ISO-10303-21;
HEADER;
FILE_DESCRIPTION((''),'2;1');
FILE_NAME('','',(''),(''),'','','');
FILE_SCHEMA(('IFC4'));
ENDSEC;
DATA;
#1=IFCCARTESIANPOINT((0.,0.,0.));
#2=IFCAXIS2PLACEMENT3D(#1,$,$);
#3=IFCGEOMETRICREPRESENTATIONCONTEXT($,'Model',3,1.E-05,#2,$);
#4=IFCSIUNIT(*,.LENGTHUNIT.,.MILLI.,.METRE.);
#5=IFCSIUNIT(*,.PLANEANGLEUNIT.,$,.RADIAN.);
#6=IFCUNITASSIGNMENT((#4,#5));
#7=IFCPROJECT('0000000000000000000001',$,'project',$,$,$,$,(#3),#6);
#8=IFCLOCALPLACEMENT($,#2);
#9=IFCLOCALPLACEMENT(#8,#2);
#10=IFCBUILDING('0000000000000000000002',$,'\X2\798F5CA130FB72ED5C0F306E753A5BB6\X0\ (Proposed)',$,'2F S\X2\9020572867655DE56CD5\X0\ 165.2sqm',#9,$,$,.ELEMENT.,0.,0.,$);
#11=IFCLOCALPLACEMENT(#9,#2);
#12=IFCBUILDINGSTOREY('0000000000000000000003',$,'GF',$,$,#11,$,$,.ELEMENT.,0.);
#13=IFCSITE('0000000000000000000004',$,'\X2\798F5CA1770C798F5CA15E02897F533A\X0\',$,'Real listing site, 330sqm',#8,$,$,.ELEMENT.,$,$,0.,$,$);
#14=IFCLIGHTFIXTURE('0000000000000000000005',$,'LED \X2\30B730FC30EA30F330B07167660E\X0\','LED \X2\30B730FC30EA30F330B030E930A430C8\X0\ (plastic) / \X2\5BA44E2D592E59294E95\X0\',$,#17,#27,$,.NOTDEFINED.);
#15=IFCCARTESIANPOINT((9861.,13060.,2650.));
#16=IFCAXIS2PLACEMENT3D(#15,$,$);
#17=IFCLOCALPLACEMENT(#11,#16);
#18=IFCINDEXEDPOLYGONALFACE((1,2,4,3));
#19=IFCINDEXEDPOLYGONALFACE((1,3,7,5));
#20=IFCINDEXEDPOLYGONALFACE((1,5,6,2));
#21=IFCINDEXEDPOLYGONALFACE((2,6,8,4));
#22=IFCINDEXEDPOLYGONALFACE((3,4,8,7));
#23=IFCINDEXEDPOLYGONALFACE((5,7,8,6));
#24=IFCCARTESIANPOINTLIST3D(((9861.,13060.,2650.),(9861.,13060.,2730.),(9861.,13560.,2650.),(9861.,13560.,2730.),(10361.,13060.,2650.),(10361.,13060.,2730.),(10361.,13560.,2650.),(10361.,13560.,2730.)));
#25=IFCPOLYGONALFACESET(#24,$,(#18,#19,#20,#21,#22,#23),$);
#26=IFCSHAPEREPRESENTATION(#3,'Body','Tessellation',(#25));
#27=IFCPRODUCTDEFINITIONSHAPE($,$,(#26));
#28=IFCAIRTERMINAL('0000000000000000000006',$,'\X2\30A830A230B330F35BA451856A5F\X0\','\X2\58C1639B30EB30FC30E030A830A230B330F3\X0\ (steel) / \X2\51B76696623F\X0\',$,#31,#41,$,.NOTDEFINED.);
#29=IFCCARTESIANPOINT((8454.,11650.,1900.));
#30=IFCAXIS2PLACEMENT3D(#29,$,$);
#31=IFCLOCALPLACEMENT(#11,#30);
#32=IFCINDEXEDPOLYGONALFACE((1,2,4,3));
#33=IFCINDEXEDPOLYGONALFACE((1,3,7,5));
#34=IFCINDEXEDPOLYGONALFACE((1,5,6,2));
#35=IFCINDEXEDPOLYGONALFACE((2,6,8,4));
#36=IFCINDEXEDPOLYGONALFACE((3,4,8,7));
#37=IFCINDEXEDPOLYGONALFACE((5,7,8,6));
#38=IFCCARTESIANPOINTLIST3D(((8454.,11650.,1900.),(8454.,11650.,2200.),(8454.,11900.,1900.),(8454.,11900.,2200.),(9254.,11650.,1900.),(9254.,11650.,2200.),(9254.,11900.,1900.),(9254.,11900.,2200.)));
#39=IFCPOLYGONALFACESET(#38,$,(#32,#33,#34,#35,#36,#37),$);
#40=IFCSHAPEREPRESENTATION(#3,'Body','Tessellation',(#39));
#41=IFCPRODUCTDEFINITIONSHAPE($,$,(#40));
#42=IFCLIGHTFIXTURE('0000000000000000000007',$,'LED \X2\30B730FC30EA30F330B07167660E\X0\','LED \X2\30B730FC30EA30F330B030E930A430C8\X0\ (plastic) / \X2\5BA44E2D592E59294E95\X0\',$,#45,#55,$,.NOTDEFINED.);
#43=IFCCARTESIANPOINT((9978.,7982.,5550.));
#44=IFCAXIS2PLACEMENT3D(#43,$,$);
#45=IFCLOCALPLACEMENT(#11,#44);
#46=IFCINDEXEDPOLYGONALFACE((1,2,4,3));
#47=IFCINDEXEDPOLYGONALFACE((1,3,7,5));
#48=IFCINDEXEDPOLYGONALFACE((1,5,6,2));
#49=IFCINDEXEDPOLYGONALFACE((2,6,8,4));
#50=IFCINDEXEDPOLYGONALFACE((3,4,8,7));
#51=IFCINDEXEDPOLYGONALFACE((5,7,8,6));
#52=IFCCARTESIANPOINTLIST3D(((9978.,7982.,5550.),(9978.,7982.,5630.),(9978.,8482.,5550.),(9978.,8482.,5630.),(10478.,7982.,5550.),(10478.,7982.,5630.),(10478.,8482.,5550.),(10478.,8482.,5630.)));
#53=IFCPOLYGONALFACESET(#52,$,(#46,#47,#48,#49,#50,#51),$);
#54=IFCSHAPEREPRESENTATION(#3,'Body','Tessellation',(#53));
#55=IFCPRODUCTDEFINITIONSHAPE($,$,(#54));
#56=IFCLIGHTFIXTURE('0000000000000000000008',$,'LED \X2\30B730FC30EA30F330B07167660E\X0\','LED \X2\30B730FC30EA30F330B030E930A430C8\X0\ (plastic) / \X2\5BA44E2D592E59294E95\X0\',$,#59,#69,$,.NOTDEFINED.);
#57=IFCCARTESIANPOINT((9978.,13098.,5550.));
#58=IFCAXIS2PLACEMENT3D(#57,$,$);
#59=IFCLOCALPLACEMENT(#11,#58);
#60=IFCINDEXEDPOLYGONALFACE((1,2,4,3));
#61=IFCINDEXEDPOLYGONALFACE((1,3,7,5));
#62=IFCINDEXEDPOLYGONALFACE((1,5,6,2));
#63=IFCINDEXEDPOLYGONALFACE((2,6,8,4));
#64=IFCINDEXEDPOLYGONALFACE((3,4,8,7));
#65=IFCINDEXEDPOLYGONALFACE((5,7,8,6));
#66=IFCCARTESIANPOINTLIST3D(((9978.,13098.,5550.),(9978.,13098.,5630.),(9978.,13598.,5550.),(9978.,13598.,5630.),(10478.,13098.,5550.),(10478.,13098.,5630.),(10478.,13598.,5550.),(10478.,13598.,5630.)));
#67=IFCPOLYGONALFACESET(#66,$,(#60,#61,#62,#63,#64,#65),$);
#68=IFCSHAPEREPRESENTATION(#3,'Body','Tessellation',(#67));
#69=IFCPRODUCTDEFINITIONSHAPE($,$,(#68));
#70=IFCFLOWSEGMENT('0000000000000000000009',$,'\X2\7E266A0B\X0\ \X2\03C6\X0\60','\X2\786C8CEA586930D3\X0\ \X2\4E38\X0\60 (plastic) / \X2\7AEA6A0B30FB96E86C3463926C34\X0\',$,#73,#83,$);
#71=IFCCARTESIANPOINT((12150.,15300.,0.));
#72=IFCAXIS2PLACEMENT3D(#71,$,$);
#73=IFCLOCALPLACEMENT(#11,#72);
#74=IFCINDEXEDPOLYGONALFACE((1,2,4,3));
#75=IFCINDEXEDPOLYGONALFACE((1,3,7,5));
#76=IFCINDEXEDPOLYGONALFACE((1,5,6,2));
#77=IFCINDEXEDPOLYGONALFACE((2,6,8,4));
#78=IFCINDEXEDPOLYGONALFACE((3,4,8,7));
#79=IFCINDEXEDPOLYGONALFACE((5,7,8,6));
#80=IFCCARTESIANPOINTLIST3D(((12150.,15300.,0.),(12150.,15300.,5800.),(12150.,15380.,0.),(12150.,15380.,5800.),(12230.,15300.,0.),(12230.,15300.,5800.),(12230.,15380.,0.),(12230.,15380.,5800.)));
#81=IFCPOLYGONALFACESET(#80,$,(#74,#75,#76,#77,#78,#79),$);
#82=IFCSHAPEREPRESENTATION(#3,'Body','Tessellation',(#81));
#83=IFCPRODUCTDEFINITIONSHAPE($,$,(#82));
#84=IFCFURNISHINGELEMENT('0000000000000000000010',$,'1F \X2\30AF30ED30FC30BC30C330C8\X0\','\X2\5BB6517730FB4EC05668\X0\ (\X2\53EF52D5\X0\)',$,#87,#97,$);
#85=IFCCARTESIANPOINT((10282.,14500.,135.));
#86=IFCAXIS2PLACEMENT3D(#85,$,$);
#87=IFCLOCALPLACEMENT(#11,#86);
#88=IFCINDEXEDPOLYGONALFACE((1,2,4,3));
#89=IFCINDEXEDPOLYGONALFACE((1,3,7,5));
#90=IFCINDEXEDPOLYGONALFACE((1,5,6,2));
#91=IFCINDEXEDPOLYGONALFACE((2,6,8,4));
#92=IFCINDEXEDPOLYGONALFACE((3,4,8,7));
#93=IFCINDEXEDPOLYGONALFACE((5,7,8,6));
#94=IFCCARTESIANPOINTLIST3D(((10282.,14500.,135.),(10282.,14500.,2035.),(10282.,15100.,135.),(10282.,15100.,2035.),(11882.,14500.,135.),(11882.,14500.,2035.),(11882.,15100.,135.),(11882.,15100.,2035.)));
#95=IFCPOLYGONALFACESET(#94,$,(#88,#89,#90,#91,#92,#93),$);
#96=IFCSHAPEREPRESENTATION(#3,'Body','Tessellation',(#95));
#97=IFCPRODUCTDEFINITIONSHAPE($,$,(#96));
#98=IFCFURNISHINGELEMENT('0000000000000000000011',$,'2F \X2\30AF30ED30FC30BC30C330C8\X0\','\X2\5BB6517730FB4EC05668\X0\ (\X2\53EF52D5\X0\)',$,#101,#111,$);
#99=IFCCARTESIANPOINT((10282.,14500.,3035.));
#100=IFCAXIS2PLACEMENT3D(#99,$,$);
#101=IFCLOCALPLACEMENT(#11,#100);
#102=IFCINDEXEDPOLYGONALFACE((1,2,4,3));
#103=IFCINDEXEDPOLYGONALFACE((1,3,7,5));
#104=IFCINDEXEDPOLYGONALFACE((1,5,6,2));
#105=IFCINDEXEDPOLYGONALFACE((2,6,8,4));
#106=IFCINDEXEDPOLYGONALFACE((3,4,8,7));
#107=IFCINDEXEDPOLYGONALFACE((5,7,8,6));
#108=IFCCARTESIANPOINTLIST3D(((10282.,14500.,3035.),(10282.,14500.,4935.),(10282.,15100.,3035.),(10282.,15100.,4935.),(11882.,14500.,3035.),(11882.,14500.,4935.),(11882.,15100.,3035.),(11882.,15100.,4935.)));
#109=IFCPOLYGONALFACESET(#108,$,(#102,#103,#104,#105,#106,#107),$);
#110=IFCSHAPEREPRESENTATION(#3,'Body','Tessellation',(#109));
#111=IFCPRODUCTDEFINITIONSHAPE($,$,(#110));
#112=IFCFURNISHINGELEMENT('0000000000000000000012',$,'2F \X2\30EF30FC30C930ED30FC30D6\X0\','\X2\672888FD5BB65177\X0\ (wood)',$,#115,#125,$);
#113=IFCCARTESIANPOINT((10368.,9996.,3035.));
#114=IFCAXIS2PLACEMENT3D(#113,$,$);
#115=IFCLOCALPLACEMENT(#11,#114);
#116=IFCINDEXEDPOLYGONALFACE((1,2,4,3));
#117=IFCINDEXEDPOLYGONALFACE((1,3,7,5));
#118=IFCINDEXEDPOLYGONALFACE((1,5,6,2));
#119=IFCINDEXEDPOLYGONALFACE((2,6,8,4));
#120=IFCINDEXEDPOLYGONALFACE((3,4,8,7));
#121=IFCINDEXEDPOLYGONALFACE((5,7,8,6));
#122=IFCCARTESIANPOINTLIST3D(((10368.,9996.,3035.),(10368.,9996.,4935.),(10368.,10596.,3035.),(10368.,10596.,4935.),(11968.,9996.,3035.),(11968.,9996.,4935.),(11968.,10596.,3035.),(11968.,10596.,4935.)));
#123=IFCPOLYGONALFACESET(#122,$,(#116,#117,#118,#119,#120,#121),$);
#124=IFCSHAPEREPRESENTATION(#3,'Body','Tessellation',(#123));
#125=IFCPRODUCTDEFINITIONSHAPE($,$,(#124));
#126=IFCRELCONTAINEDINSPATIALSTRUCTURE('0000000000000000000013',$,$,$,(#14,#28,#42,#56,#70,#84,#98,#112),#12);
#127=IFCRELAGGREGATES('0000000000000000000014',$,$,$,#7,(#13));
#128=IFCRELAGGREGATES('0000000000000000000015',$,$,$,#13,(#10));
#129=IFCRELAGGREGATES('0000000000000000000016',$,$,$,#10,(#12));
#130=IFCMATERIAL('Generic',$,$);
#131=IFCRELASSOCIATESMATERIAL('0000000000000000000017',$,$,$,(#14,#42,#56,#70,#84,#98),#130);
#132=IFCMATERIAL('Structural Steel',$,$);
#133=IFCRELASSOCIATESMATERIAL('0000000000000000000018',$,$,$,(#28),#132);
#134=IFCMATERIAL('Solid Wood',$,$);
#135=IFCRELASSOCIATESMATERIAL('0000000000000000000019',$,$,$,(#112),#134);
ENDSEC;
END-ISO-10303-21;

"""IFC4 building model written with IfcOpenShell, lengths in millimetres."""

from ifc_helpers import new_model, si_unit, frame, frame_2d, origin, place, context, project, spatial, rectangle, extrude, material, element, save


model = new_model("IFC4")

# Units and contexts
model_context = context("Model", 3, precision=1e-05, world=origin())
ifc_project = project(units=[si_unit("LENGTHUNIT", "METRE", prefix="MILLI"), si_unit("PLANEANGLEUNIT", "RADIAN")], contexts=[model_context])

# Site, building, storey
site_placement = place(None, origin())
site = spatial("IfcSite", under=ifc_project, at=site_placement, Name="福岡県福岡市西区", ObjectType="Real listing site, 330sqm", CompositionType="ELEMENT", RefElevation=0.0)
building_placement = place(site_placement, origin())
building = spatial("IfcBuilding", under=site, at=building_placement, Name="福岡・狭小の町家 (Proposed)", ObjectType="2F S造在来工法 165.2sqm", CompositionType="ELEMENT", ElevationOfRefHeight=0.0, ElevationOfTerrain=0.0)
storey_placement = place(building_placement, origin())
storey = spatial("IfcBuildingStorey", under=building, at=storey_placement, Name="GF", CompositionType="ELEMENT", Elevation=0.0)

# Shared definitions
ifc_material_1 = material(Name="Solid Wood")

# Shared definitions
ifc_material_2 = material(Name="Structural Steel")

# Shared definitions
ifc_material_3 = material(Name="Generic")

# Light fixture
light_fixture_1_placement = place(storey_placement, frame((9861.0, 13060.0, 2650.0)))
element("IfcLightFixture", 1, at=light_fixture_1_placement, inside=storey, material=ifc_material_3, Name="LED シーリング照明", Description="LED シーリングライト (plastic) / 室中央天井", PredefinedType="NOTDEFINED", context=model_context, shape_type="SweptSolid", body=[
    extrude(rectangle(XDim=500.0, YDim=500.0, at=frame_2d((250.0, 250.0))), frame((9861.0, 13060.0, 2650.0)), (0.0, 0.0, 1.0), 80.0),
])

# Air terminal
air_terminal_placement = place(storey_placement, frame((8454.0, 11650.0, 1900.0)))
element("IfcAirTerminal", 2, at=air_terminal_placement, inside=storey, material=ifc_material_2, Name="エアコン室内機", Description="壁掛ルームエアコン (steel) / 冷暖房", PredefinedType="NOTDEFINED", context=model_context, shape_type="SweptSolid", body=[
    extrude(rectangle(XDim=800.0, YDim=250.0, at=frame_2d((400.0, 125.0))), frame((8454.0, 11650.0, 1900.0)), (0.0, 0.0, 1.0), 300.0),
])

# Light fixtures
light_fixture_2_placement = place(storey_placement, frame((9978.0, 7982.0, 5550.0)))
element("IfcLightFixture", 3, at=light_fixture_2_placement, inside=storey, material=ifc_material_3, Name="LED シーリング照明", Description="LED シーリングライト (plastic) / 室中央天井", PredefinedType="NOTDEFINED", context=model_context, shape_type="SweptSolid", body=[
    extrude(rectangle(XDim=500.0, YDim=500.0, at=frame_2d((250.0, 250.0))), frame((9978.0, 7982.0, 5550.0)), (0.0, 0.0, 1.0), 80.0),
])
light_fixture_3_placement = place(storey_placement, frame((9978.0, 13098.0, 5550.0)))
element("IfcLightFixture", 4, at=light_fixture_3_placement, inside=storey, material=ifc_material_3, Name="LED シーリング照明", Description="LED シーリングライト (plastic) / 室中央天井", PredefinedType="NOTDEFINED", context=model_context, shape_type="SweptSolid", body=[
    extrude(rectangle(XDim=500.0, YDim=500.0, at=frame_2d((250.0, 250.0))), frame((9978.0, 13098.0, 5550.0)), (0.0, 0.0, 1.0), 80.0),
])

# Flow segment
flow_segment_placement = place(storey_placement, frame((12150.0, 15300.0, 0.0)))
element("IfcFlowSegment", 5, at=flow_segment_placement, inside=storey, material=ifc_material_3, Name="縦樋 φ60", Description="硬質塩ビ 丸60 (plastic) / 竪樋・雨水排水", context=model_context, shape_type="SweptSolid", body=[
    extrude(rectangle(XDim=80.0, YDim=80.0, at=frame_2d((40.0, 40.0))), frame((12150.0, 15300.0, 0.0)), (0.0, 0.0, 1.0), 5800.0),
])

# Furnishing elements
furnishing_1_placement = place(storey_placement, frame((10282.0, 14500.0, 135.0)))
element("IfcFurnishingElement", 6, at=furnishing_1_placement, inside=storey, material=ifc_material_3, Name="1F クローゼット", Description="家具・什器 (可動)", context=model_context, shape_type="SweptSolid", body=[
    extrude(rectangle(XDim=1600.0, YDim=600.0, at=frame_2d((800.0, 300.0))), frame((10282.0, 14500.0, 135.0)), (0.0, 0.0, 1.0), 1900.0),
])
furnishing_2_placement = place(storey_placement, frame((10282.0, 14500.0, 3035.0)))
element("IfcFurnishingElement", 7, at=furnishing_2_placement, inside=storey, material=ifc_material_3, Name="2F クローゼット", Description="家具・什器 (可動)", context=model_context, shape_type="SweptSolid", body=[
    extrude(rectangle(XDim=1600.0, YDim=600.0, at=frame_2d((800.0, 300.0))), frame((10282.0, 14500.0, 3035.0)), (0.0, 0.0, 1.0), 1900.0),
])
furnishing_3_placement = place(storey_placement, frame((10368.0, 9996.0, 3035.0)))
element("IfcFurnishingElement", 8, at=furnishing_3_placement, inside=storey, material=ifc_material_1, Name="2F ワードローブ", Description="木製家具 (wood)", context=model_context, shape_type="SweptSolid", body=[
    extrude(rectangle(XDim=1600.0, YDim=600.0, at=frame_2d((800.0, 300.0))), frame((10368.0, 9996.0, 3035.0)), (0.0, 0.0, 1.0), 1900.0),
])

save(model, "model.ifc")
